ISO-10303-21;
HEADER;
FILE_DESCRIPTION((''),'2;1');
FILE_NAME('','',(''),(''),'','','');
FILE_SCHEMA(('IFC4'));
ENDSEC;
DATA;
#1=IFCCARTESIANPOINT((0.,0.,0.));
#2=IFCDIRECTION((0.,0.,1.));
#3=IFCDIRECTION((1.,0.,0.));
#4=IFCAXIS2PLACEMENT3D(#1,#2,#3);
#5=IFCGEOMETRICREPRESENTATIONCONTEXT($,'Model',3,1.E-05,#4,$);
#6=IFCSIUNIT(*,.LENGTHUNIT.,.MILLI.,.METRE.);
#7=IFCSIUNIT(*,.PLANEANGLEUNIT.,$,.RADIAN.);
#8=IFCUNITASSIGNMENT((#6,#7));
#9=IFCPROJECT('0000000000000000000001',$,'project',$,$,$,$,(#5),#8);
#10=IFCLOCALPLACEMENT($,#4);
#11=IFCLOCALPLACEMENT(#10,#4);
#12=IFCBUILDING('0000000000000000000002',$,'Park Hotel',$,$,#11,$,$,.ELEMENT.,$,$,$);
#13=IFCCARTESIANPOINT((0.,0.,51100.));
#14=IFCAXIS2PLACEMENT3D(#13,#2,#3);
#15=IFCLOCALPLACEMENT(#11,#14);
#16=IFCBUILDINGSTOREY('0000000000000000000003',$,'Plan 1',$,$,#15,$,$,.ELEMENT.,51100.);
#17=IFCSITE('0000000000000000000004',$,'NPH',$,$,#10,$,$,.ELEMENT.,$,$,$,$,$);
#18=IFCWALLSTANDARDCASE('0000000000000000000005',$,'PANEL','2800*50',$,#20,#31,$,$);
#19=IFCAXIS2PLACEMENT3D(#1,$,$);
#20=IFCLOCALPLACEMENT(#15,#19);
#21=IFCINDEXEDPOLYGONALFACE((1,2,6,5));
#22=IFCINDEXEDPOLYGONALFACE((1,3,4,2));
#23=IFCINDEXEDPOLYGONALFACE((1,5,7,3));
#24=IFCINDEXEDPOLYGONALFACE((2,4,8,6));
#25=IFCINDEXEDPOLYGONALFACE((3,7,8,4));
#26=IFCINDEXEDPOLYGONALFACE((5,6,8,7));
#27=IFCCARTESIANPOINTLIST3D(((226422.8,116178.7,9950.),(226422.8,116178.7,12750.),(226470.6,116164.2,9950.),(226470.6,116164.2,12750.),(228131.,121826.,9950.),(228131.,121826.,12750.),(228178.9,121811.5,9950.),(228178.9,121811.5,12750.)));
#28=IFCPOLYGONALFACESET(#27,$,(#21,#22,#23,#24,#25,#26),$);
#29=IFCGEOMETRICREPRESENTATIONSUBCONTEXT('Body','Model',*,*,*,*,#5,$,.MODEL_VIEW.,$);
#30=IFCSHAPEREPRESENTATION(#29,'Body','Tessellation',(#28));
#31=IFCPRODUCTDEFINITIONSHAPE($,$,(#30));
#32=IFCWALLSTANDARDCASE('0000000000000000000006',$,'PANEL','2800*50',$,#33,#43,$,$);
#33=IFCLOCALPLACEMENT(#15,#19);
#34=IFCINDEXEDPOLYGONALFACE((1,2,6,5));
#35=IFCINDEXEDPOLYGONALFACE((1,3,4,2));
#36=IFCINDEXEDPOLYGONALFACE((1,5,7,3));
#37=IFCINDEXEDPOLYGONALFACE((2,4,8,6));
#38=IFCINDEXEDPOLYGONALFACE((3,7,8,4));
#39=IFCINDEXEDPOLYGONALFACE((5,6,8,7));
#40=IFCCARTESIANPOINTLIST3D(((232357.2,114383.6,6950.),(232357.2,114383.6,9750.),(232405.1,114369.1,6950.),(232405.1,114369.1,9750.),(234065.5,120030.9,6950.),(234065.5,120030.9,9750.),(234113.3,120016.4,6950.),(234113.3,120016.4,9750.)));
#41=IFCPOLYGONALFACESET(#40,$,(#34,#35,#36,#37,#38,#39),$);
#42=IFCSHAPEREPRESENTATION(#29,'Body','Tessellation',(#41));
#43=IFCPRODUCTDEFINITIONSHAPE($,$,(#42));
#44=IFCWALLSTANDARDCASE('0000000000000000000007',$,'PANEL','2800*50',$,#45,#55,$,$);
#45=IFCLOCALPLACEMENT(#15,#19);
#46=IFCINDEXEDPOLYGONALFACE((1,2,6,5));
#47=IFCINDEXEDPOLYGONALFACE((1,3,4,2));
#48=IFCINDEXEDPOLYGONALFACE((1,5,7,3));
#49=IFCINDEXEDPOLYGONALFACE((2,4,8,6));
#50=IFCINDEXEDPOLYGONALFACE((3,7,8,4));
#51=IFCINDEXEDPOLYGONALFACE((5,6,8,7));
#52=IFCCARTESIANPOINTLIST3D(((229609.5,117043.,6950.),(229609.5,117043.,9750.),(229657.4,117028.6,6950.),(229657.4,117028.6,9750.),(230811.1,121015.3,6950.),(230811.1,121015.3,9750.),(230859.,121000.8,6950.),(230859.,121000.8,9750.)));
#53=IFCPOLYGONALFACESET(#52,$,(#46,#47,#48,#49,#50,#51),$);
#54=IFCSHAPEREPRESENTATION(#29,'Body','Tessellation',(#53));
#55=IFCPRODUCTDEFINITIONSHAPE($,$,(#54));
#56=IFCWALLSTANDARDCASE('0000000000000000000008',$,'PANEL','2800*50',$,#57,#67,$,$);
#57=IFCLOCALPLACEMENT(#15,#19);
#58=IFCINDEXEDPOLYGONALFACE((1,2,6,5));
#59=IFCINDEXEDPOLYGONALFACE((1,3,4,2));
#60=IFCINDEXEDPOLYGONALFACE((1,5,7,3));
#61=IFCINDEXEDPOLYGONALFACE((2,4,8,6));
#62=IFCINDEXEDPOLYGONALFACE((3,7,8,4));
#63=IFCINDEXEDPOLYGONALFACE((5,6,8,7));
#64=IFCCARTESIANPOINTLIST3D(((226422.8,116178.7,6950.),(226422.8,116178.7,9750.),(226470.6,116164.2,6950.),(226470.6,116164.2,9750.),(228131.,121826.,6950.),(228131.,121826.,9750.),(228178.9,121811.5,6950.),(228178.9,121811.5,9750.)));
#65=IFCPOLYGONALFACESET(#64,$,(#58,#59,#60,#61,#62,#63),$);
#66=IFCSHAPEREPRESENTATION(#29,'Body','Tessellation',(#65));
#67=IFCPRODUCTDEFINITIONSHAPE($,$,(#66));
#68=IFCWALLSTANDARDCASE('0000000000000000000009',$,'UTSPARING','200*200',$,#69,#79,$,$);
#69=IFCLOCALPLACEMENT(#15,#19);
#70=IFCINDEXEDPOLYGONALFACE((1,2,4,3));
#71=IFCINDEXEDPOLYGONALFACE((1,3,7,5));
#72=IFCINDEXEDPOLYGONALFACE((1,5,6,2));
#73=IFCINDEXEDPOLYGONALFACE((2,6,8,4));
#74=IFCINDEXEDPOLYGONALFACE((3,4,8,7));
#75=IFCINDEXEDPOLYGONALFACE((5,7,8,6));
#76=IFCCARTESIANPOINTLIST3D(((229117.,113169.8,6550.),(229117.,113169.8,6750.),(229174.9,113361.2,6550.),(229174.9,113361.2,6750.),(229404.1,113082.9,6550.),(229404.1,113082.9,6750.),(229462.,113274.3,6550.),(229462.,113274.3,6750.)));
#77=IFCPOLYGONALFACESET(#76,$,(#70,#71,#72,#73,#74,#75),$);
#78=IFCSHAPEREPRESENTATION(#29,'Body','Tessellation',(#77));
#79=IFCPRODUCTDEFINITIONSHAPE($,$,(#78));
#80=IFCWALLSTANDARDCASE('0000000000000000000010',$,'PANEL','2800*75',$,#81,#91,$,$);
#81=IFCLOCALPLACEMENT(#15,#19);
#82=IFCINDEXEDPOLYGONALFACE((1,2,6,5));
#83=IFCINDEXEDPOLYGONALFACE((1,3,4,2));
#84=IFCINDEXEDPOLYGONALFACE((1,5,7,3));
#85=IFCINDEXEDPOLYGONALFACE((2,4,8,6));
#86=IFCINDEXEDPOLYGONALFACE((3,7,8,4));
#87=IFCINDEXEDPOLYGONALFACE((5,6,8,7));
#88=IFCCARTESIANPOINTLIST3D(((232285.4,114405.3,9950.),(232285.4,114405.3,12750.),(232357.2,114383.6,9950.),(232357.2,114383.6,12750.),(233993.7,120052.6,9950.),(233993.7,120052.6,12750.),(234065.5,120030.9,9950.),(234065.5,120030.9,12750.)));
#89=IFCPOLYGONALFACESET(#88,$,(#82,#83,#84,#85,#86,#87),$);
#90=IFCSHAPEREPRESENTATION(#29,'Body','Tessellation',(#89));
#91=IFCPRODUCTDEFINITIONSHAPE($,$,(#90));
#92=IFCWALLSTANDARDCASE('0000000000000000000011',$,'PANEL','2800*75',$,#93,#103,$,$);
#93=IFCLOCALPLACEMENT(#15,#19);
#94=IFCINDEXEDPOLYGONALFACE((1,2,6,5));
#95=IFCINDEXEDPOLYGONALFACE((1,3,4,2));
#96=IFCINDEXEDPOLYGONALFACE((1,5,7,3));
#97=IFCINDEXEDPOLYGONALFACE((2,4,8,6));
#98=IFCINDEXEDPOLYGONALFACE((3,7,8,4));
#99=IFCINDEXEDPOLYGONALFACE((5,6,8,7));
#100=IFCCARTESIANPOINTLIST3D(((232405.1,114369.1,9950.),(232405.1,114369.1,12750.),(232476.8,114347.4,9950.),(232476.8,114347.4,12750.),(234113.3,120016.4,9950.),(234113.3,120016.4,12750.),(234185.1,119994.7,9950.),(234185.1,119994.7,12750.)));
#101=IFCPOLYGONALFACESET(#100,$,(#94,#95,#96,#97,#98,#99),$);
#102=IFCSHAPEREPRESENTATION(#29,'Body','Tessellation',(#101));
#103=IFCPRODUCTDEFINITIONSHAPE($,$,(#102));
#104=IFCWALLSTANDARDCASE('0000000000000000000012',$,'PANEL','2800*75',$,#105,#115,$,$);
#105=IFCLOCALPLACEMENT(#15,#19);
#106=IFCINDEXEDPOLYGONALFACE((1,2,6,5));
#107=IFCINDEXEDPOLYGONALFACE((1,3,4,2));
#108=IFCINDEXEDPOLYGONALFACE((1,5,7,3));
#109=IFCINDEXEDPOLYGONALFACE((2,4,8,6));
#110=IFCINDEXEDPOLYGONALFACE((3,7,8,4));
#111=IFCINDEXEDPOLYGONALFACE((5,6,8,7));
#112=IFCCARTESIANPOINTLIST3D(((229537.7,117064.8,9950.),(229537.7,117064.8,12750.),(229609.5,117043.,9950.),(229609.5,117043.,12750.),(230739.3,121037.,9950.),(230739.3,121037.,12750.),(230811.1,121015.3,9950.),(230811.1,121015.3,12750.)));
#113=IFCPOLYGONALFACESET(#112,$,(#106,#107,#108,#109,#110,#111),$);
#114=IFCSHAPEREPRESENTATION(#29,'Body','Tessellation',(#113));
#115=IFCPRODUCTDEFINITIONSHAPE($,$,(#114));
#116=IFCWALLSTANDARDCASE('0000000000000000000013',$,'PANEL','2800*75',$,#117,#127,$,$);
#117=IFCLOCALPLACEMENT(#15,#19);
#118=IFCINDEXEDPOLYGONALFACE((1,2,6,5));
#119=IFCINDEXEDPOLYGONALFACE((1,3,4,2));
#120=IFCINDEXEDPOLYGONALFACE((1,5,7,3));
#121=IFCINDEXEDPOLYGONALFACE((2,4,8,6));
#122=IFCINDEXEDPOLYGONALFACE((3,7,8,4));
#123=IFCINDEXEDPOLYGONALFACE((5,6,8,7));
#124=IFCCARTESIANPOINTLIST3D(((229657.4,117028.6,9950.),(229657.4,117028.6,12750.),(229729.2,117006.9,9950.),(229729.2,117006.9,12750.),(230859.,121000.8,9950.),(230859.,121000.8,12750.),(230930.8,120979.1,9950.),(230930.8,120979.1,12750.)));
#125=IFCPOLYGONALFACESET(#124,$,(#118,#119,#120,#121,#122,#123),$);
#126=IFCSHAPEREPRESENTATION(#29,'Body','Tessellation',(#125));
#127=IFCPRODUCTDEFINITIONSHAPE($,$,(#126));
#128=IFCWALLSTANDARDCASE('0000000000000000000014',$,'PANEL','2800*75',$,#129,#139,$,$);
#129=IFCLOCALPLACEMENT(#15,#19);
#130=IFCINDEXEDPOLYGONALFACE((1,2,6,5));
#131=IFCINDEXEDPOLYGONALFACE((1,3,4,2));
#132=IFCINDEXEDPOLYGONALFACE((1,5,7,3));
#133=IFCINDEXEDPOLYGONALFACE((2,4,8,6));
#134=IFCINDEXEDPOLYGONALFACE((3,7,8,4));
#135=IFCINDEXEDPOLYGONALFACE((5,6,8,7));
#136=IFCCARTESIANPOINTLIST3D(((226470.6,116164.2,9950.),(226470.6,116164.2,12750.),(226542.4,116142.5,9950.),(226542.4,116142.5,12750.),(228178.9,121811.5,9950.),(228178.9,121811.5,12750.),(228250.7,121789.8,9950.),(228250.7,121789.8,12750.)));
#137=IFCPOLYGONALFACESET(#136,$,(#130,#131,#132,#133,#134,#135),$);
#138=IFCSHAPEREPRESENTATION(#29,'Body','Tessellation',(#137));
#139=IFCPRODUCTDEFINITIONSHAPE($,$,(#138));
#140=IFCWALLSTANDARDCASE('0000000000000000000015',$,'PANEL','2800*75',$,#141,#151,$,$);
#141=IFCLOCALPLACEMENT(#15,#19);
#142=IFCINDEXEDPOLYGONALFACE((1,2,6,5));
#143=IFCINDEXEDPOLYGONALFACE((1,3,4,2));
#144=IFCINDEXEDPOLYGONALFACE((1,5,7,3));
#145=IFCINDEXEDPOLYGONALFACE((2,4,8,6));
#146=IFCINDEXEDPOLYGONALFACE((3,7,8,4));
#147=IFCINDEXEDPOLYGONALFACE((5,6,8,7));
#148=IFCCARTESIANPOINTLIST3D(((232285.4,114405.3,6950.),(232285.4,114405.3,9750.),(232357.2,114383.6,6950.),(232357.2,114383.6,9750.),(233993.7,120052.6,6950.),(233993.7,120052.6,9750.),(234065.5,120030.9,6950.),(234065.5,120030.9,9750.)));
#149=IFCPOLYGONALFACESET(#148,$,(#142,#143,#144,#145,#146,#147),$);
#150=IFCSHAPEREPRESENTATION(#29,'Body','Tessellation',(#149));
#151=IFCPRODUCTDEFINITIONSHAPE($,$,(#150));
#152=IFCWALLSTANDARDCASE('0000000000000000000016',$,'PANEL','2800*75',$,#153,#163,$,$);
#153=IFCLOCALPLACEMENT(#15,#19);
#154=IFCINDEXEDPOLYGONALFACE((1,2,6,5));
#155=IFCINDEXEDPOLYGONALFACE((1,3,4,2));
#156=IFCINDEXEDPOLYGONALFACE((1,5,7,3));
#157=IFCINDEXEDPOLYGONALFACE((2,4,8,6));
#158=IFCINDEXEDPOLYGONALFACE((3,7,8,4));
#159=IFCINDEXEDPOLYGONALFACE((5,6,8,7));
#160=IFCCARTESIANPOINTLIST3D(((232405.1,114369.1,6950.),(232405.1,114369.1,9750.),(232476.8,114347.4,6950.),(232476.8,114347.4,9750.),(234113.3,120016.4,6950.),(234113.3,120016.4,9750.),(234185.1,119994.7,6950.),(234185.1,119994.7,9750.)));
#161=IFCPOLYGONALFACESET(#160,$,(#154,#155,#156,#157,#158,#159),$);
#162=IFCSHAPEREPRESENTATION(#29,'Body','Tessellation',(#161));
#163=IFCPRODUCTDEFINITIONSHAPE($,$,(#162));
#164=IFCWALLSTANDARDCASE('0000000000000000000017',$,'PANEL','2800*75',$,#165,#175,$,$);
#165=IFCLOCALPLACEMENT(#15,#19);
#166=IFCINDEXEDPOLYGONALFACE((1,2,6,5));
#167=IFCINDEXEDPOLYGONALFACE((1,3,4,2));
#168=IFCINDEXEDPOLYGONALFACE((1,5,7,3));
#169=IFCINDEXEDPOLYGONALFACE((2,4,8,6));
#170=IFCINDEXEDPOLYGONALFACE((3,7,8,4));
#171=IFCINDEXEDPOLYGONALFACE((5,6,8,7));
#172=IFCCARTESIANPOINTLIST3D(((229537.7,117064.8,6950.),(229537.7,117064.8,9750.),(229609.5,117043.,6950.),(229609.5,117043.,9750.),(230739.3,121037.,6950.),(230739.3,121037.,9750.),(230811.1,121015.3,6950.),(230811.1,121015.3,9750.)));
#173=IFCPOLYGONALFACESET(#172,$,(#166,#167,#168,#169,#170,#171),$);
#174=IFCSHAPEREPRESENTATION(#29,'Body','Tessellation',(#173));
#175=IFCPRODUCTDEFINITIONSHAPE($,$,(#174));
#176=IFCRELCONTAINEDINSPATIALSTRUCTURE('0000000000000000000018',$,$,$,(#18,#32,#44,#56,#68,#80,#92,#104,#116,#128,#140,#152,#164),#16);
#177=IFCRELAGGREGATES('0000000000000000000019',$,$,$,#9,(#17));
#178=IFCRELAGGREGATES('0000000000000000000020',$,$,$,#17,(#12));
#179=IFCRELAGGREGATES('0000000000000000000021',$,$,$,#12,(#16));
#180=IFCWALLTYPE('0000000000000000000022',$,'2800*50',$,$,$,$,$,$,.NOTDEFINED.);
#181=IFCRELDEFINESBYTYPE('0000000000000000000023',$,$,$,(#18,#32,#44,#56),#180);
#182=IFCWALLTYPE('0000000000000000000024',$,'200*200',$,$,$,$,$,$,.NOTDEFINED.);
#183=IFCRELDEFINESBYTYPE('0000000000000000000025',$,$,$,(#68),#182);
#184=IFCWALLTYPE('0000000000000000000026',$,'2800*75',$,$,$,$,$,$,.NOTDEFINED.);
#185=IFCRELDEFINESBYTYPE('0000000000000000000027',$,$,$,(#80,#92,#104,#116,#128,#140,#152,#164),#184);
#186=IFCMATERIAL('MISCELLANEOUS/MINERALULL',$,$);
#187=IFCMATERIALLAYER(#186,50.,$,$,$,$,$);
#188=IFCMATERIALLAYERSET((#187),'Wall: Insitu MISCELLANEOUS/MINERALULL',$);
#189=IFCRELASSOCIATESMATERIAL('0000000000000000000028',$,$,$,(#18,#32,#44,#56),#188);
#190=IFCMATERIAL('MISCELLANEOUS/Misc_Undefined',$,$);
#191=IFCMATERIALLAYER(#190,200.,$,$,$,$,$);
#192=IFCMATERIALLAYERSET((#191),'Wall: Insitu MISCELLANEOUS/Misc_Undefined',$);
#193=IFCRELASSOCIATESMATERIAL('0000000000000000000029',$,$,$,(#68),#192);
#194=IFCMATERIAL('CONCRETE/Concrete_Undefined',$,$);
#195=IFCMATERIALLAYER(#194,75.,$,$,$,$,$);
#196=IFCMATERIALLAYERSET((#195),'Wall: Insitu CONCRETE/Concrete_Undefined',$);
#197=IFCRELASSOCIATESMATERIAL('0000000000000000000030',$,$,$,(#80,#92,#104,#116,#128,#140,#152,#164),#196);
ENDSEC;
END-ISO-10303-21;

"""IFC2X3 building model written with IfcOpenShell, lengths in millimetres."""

from ifc_helpers import new_model, si_unit, frame, frame_2d, origin_with_axes, place, context, subcontext, project, spatial, rectangle, extrude, material, layer, layer_set, layer_usage, type_object, element, save


model = new_model("IFC2X3")

# Units and contexts
model_context = context("Model", 3, precision=1e-05, world=origin_with_axes())
body_context = subcontext(model_context, "Body", "Model", "MODEL_VIEW")
ifc_project = project(units=[si_unit("LENGTHUNIT", "METRE", prefix="MILLI"), si_unit("PLANEANGLEUNIT", "RADIAN")], contexts=[model_context])

# Site, building, storey
site_placement = place(None, origin_with_axes())
site = spatial("IfcSite", under=ifc_project, at=site_placement, Name="NPH", CompositionType="ELEMENT")
building_placement = place(site_placement, origin_with_axes())
building = spatial("IfcBuilding", under=site, at=building_placement, Name="Park Hotel", CompositionType="ELEMENT")
storey_placement = place(building_placement, frame((0.0, 0.0, 51100.0), z_axis=(0.0, 0.0, 1.0), x_axis=(1.0, 0.0, 0.0)))
storey = spatial("IfcBuildingStorey", under=building, at=storey_placement, Name="Plan 1", CompositionType="ELEMENT", Elevation=51100.0)

# Walls
ifc_material_1 = material(Name="MISCELLANEOUS/Misc_Undefined")
ifc_material_2 = material(Name="MISCELLANEOUS/MINERALULL")
ifc_layer_1 = layer(ifc_material_2, 50.0)
ifc_layer_set_1 = layer_set([ifc_layer_1], Name="Wall: Insitu MISCELLANEOUS/MINERALULL")
wall_type_1 = type_object("IfcWallType", Name="2800*50", PredefinedType="NOTDEFINED")
ifc_layer_usage_1 = layer_usage(ifc_layer_set_1, "AXIS2", "POSITIVE", -25.0)
wall_1_placement = place(storey_placement, frame((226446.7, 116171.5, 9950.0), z_axis=(0.0, 0.0, 1.0), x_axis=(0.289537, 0.957167, 0.0)))
element("IfcWallStandardCase", 1, at=wall_1_placement, inside=storey, type_object=wall_type_1, material=ifc_layer_usage_1, Name="PANEL", Description="2800*50", context=body_context, shape_type="SweptSolid", body=[
    extrude(rectangle(XDim=5900.0, YDim=50.0, at=frame_2d((0.0, 2950.0), x_axis=(0.0, -1.0))), frame((0.0, 0.0, 0.0), z_axis=(0.0, 0.0, 1.0), x_axis=(0.0, -1.0, 0.0)), (0.0, 0.0, 1.0), 2800.0),
])
ifc_layer_usage_2 = layer_usage(ifc_layer_set_1, "AXIS2", "POSITIVE", -25.0)
wall_2_placement = place(storey_placement, frame((232381.1, 114376.3, 6950.0), z_axis=(0.0, 0.0, 1.0), x_axis=(0.289537, 0.957167, 0.0)))
element("IfcWallStandardCase", 2, at=wall_2_placement, inside=storey, type_object=wall_type_1, material=ifc_layer_usage_2, Name="PANEL", Description="2800*50", context=body_context, shape_type="SweptSolid", body=[
    extrude(rectangle(XDim=5900.0, YDim=50.0, at=frame_2d((0.0, 2950.0), x_axis=(0.0, -1.0))), frame((0.0, 0.0, 0.0), z_axis=(0.0, 0.0, 1.0), x_axis=(0.0, -1.0, 0.0)), (0.0, 0.0, 1.0), 2800.0),
])
ifc_layer_usage_3 = layer_usage(ifc_layer_set_1, "AXIS2", "POSITIVE", -25.0)
wall_3_placement = place(storey_placement, frame((229633.5, 117035.8, 6950.0), z_axis=(0.0, 0.0, 1.0), x_axis=(0.289537, 0.957167, 0.0)))
element("IfcWallStandardCase", 3, at=wall_3_placement, inside=storey, type_object=wall_type_1, material=ifc_layer_usage_3, Name="PANEL", Description="2800*50", context=body_context, shape_type="SweptSolid", body=[
    extrude(rectangle(XDim=4150.0, YDim=50.0, at=frame_2d((0.0, 2075.0), x_axis=(0.0, -1.0))), frame((0.0, 0.0, 0.0), z_axis=(0.0, 0.0, 1.0), x_axis=(0.0, -1.0, 0.0)), (0.0, 0.0, 1.0), 2800.0),
])
ifc_layer_usage_4 = layer_usage(ifc_layer_set_1, "AXIS2", "POSITIVE", -25.0)
wall_4_placement = place(storey_placement, frame((226446.7, 116171.5, 6950.0), z_axis=(0.0, 0.0, 1.0), x_axis=(0.289537, 0.957167, 0.0)))
element("IfcWallStandardCase", 4, at=wall_4_placement, inside=storey, type_object=wall_type_1, material=ifc_layer_usage_4, Name="PANEL", Description="2800*50", context=body_context, shape_type="SweptSolid", body=[
    extrude(rectangle(XDim=5900.0, YDim=50.0, at=frame_2d((0.0, 2950.0), x_axis=(0.0, -1.0))), frame((0.0, 0.0, 0.0), z_axis=(0.0, 0.0, 1.0), x_axis=(0.0, -1.0, 0.0)), (0.0, 0.0, 1.0), 2800.0),
])
ifc_layer_2 = layer(ifc_material_1, 200.0)
ifc_layer_set_2 = layer_set([ifc_layer_2], Name="Wall: Insitu MISCELLANEOUS/Misc_Undefined")
ifc_layer_usage_5 = layer_usage(ifc_layer_set_2, "AXIS2", "POSITIVE", -100.0)
wall_type_2 = type_object("IfcWallType", Name="200*200", PredefinedType="NOTDEFINED")
wall_5_placement = place(storey_placement, frame((229145.9, 113265.5, 6550.0), z_axis=(0.0, 0.0, 1.0), x_axis=(0.957163, -0.289549, 0.0)))
element("IfcWallStandardCase", 5, at=wall_5_placement, inside=storey, type_object=wall_type_2, material=ifc_layer_usage_5, Name="UTSPARING", Description="200*200", context=body_context, shape_type="SweptSolid", body=[
    extrude(rectangle(XDim=300.0, YDim=200.0, at=frame_2d((0.0, 150.0), x_axis=(0.0, -1.0))), frame((0.0, 0.0, 0.0), z_axis=(0.0, 0.0, 1.0), x_axis=(0.0, -1.0, 0.0)), (0.0, 0.0, 1.0), 200.0),
])
ifc_material_3 = material(Name="CONCRETE/Concrete_Undefined")
ifc_layer_3 = layer(ifc_material_3, 75.0)
ifc_layer_set_3 = layer_set([ifc_layer_3], Name="Wall: Insitu CONCRETE/Concrete_Undefined")
ifc_layer_usage_6 = layer_usage(ifc_layer_set_3, "AXIS2", "POSITIVE", -37.5)
wall_type_3 = type_object("IfcWallType", Name="2800*75", PredefinedType="NOTDEFINED")
wall_6_placement = place(storey_placement, frame((232321.3, 114394.4, 9950.0), z_axis=(0.0, 0.0, 1.0), x_axis=(0.289537, 0.957167, 0.0)))
element("IfcWallStandardCase", 6, at=wall_6_placement, inside=storey, type_object=wall_type_3, material=ifc_layer_usage_6, Name="PANEL", Description="2800*75", context=body_context, shape_type="SweptSolid", body=[
    extrude(rectangle(XDim=5900.0, YDim=75.0, at=frame_2d((0.0, 2950.0), x_axis=(0.0, -1.0))), frame((0.0, 0.0, 0.0), z_axis=(0.0, 0.0, 1.0), x_axis=(0.0, -1.0, 0.0)), (0.0, 0.0, 1.0), 2800.0),
])
ifc_layer_usage_7 = layer_usage(ifc_layer_set_3, "AXIS2", "POSITIVE", -37.5)
wall_7_placement = place(storey_placement, frame((232441.0, 114358.2, 9950.0), z_axis=(0.0, 0.0, 1.0), x_axis=(0.289537, 0.957167, 0.0)))
element("IfcWallStandardCase", 7, at=wall_7_placement, inside=storey, type_object=wall_type_3, material=ifc_layer_usage_7, Name="PANEL", Description="2800*75", context=body_context, shape_type="SweptSolid", body=[
    extrude(rectangle(XDim=5900.0, YDim=75.0, at=frame_2d((0.0, 2950.0), x_axis=(0.0, -1.0))), frame((0.0, 0.0, 0.0), z_axis=(0.0, 0.0, 1.0), x_axis=(0.0, -1.0, 0.0)), (0.0, 0.0, 1.0), 2800.0),
])
ifc_layer_usage_8 = layer_usage(ifc_layer_set_3, "AXIS2", "POSITIVE", -37.5)
wall_8_placement = place(storey_placement, frame((229573.6, 117053.9, 9950.0), z_axis=(0.0, 0.0, 1.0), x_axis=(0.289537, 0.957167, 0.0)))
element("IfcWallStandardCase", 8, at=wall_8_placement, inside=storey, type_object=wall_type_3, material=ifc_layer_usage_8, Name="PANEL", Description="2800*75", context=body_context, shape_type="SweptSolid", body=[
    extrude(rectangle(XDim=4150.0, YDim=75.0, at=frame_2d((0.0, 2075.0), x_axis=(0.0, -1.0))), frame((0.0, 0.0, 0.0), z_axis=(0.0, 0.0, 1.0), x_axis=(0.0, -1.0, 0.0)), (0.0, 0.0, 1.0), 2800.0),
])
ifc_layer_usage_9 = layer_usage(ifc_layer_set_3, "AXIS2", "POSITIVE", -37.5)
wall_9_placement = place(storey_placement, frame((229693.3, 117017.7, 9950.0), z_axis=(0.0, 0.0, 1.0), x_axis=(0.289537, 0.957167, 0.0)))
element("IfcWallStandardCase", 9, at=wall_9_placement, inside=storey, type_object=wall_type_3, material=ifc_layer_usage_9, Name="PANEL", Description="2800*75", context=body_context, shape_type="SweptSolid", body=[
    extrude(rectangle(XDim=4150.0, YDim=75.0, at=frame_2d((0.0, 2075.0), x_axis=(0.0, -1.0))), frame((0.0, 0.0, 0.0), z_axis=(0.0, 0.0, 1.0), x_axis=(0.0, -1.0, 0.0)), (0.0, 0.0, 1.0), 2800.0),
])
ifc_layer_usage_10 = layer_usage(ifc_layer_set_3, "AXIS2", "POSITIVE", -37.5)
wall_10_placement = place(storey_placement, frame((226506.5, 116153.4, 9950.0), z_axis=(0.0, 0.0, 1.0), x_axis=(0.289537, 0.957167, 0.0)))
element("IfcWallStandardCase", 10, at=wall_10_placement, inside=storey, type_object=wall_type_3, material=ifc_layer_usage_10, Name="PANEL", Description="2800*75", context=body_context, shape_type="SweptSolid", body=[
    extrude(rectangle(XDim=5900.0, YDim=75.0, at=frame_2d((0.0, 2950.0), x_axis=(0.0, -1.0))), frame((0.0, 0.0, 0.0), z_axis=(0.0, 0.0, 1.0), x_axis=(0.0, -1.0, 0.0)), (0.0, 0.0, 1.0), 2800.0),
])
ifc_layer_usage_11 = layer_usage(ifc_layer_set_3, "AXIS2", "POSITIVE", -37.5)
wall_11_placement = place(storey_placement, frame((232321.3, 114394.4, 6950.0), z_axis=(0.0, 0.0, 1.0), x_axis=(0.289537, 0.957167, 0.0)))
element("IfcWallStandardCase", 11, at=wall_11_placement, inside=storey, type_object=wall_type_3, material=ifc_layer_usage_11, Name="PANEL", Description="2800*75", context=body_context, shape_type="SweptSolid", body=[
    extrude(rectangle(XDim=5900.0, YDim=75.0, at=frame_2d((0.0, 2950.0), x_axis=(0.0, -1.0))), frame((0.0, 0.0, 0.0), z_axis=(0.0, 0.0, 1.0), x_axis=(0.0, -1.0, 0.0)), (0.0, 0.0, 1.0), 2800.0),
])
ifc_layer_usage_12 = layer_usage(ifc_layer_set_3, "AXIS2", "POSITIVE", -37.5)
wall_12_placement = place(storey_placement, frame((232441.0, 114358.2, 6950.0), z_axis=(0.0, 0.0, 1.0), x_axis=(0.289537, 0.957167, 0.0)))
element("IfcWallStandardCase", 12, at=wall_12_placement, inside=storey, type_object=wall_type_3, material=ifc_layer_usage_12, Name="PANEL", Description="2800*75", context=body_context, shape_type="SweptSolid", body=[
    extrude(rectangle(XDim=5900.0, YDim=75.0, at=frame_2d((0.0, 2950.0), x_axis=(0.0, -1.0))), frame((0.0, 0.0, 0.0), z_axis=(0.0, 0.0, 1.0), x_axis=(0.0, -1.0, 0.0)), (0.0, 0.0, 1.0), 2800.0),
])
ifc_layer_usage_13 = layer_usage(ifc_layer_set_3, "AXIS2", "POSITIVE", -37.5)
wall_13_placement = place(storey_placement, frame((229573.6, 117053.9, 6950.0), z_axis=(0.0, 0.0, 1.0), x_axis=(0.289537, 0.957167, 0.0)))
element("IfcWallStandardCase", 13, at=wall_13_placement, inside=storey, type_object=wall_type_3, material=ifc_layer_usage_13, Name="PANEL", Description="2800*75", context=body_context, shape_type="SweptSolid", body=[
    extrude(rectangle(XDim=4150.0, YDim=75.0, at=frame_2d((0.0, 2075.0), x_axis=(0.0, -1.0))), frame((0.0, 0.0, 0.0), z_axis=(0.0, 0.0, 1.0), x_axis=(0.0, -1.0, 0.0)), (0.0, 0.0, 1.0), 2800.0),
])

save(model, "model.ifc")
